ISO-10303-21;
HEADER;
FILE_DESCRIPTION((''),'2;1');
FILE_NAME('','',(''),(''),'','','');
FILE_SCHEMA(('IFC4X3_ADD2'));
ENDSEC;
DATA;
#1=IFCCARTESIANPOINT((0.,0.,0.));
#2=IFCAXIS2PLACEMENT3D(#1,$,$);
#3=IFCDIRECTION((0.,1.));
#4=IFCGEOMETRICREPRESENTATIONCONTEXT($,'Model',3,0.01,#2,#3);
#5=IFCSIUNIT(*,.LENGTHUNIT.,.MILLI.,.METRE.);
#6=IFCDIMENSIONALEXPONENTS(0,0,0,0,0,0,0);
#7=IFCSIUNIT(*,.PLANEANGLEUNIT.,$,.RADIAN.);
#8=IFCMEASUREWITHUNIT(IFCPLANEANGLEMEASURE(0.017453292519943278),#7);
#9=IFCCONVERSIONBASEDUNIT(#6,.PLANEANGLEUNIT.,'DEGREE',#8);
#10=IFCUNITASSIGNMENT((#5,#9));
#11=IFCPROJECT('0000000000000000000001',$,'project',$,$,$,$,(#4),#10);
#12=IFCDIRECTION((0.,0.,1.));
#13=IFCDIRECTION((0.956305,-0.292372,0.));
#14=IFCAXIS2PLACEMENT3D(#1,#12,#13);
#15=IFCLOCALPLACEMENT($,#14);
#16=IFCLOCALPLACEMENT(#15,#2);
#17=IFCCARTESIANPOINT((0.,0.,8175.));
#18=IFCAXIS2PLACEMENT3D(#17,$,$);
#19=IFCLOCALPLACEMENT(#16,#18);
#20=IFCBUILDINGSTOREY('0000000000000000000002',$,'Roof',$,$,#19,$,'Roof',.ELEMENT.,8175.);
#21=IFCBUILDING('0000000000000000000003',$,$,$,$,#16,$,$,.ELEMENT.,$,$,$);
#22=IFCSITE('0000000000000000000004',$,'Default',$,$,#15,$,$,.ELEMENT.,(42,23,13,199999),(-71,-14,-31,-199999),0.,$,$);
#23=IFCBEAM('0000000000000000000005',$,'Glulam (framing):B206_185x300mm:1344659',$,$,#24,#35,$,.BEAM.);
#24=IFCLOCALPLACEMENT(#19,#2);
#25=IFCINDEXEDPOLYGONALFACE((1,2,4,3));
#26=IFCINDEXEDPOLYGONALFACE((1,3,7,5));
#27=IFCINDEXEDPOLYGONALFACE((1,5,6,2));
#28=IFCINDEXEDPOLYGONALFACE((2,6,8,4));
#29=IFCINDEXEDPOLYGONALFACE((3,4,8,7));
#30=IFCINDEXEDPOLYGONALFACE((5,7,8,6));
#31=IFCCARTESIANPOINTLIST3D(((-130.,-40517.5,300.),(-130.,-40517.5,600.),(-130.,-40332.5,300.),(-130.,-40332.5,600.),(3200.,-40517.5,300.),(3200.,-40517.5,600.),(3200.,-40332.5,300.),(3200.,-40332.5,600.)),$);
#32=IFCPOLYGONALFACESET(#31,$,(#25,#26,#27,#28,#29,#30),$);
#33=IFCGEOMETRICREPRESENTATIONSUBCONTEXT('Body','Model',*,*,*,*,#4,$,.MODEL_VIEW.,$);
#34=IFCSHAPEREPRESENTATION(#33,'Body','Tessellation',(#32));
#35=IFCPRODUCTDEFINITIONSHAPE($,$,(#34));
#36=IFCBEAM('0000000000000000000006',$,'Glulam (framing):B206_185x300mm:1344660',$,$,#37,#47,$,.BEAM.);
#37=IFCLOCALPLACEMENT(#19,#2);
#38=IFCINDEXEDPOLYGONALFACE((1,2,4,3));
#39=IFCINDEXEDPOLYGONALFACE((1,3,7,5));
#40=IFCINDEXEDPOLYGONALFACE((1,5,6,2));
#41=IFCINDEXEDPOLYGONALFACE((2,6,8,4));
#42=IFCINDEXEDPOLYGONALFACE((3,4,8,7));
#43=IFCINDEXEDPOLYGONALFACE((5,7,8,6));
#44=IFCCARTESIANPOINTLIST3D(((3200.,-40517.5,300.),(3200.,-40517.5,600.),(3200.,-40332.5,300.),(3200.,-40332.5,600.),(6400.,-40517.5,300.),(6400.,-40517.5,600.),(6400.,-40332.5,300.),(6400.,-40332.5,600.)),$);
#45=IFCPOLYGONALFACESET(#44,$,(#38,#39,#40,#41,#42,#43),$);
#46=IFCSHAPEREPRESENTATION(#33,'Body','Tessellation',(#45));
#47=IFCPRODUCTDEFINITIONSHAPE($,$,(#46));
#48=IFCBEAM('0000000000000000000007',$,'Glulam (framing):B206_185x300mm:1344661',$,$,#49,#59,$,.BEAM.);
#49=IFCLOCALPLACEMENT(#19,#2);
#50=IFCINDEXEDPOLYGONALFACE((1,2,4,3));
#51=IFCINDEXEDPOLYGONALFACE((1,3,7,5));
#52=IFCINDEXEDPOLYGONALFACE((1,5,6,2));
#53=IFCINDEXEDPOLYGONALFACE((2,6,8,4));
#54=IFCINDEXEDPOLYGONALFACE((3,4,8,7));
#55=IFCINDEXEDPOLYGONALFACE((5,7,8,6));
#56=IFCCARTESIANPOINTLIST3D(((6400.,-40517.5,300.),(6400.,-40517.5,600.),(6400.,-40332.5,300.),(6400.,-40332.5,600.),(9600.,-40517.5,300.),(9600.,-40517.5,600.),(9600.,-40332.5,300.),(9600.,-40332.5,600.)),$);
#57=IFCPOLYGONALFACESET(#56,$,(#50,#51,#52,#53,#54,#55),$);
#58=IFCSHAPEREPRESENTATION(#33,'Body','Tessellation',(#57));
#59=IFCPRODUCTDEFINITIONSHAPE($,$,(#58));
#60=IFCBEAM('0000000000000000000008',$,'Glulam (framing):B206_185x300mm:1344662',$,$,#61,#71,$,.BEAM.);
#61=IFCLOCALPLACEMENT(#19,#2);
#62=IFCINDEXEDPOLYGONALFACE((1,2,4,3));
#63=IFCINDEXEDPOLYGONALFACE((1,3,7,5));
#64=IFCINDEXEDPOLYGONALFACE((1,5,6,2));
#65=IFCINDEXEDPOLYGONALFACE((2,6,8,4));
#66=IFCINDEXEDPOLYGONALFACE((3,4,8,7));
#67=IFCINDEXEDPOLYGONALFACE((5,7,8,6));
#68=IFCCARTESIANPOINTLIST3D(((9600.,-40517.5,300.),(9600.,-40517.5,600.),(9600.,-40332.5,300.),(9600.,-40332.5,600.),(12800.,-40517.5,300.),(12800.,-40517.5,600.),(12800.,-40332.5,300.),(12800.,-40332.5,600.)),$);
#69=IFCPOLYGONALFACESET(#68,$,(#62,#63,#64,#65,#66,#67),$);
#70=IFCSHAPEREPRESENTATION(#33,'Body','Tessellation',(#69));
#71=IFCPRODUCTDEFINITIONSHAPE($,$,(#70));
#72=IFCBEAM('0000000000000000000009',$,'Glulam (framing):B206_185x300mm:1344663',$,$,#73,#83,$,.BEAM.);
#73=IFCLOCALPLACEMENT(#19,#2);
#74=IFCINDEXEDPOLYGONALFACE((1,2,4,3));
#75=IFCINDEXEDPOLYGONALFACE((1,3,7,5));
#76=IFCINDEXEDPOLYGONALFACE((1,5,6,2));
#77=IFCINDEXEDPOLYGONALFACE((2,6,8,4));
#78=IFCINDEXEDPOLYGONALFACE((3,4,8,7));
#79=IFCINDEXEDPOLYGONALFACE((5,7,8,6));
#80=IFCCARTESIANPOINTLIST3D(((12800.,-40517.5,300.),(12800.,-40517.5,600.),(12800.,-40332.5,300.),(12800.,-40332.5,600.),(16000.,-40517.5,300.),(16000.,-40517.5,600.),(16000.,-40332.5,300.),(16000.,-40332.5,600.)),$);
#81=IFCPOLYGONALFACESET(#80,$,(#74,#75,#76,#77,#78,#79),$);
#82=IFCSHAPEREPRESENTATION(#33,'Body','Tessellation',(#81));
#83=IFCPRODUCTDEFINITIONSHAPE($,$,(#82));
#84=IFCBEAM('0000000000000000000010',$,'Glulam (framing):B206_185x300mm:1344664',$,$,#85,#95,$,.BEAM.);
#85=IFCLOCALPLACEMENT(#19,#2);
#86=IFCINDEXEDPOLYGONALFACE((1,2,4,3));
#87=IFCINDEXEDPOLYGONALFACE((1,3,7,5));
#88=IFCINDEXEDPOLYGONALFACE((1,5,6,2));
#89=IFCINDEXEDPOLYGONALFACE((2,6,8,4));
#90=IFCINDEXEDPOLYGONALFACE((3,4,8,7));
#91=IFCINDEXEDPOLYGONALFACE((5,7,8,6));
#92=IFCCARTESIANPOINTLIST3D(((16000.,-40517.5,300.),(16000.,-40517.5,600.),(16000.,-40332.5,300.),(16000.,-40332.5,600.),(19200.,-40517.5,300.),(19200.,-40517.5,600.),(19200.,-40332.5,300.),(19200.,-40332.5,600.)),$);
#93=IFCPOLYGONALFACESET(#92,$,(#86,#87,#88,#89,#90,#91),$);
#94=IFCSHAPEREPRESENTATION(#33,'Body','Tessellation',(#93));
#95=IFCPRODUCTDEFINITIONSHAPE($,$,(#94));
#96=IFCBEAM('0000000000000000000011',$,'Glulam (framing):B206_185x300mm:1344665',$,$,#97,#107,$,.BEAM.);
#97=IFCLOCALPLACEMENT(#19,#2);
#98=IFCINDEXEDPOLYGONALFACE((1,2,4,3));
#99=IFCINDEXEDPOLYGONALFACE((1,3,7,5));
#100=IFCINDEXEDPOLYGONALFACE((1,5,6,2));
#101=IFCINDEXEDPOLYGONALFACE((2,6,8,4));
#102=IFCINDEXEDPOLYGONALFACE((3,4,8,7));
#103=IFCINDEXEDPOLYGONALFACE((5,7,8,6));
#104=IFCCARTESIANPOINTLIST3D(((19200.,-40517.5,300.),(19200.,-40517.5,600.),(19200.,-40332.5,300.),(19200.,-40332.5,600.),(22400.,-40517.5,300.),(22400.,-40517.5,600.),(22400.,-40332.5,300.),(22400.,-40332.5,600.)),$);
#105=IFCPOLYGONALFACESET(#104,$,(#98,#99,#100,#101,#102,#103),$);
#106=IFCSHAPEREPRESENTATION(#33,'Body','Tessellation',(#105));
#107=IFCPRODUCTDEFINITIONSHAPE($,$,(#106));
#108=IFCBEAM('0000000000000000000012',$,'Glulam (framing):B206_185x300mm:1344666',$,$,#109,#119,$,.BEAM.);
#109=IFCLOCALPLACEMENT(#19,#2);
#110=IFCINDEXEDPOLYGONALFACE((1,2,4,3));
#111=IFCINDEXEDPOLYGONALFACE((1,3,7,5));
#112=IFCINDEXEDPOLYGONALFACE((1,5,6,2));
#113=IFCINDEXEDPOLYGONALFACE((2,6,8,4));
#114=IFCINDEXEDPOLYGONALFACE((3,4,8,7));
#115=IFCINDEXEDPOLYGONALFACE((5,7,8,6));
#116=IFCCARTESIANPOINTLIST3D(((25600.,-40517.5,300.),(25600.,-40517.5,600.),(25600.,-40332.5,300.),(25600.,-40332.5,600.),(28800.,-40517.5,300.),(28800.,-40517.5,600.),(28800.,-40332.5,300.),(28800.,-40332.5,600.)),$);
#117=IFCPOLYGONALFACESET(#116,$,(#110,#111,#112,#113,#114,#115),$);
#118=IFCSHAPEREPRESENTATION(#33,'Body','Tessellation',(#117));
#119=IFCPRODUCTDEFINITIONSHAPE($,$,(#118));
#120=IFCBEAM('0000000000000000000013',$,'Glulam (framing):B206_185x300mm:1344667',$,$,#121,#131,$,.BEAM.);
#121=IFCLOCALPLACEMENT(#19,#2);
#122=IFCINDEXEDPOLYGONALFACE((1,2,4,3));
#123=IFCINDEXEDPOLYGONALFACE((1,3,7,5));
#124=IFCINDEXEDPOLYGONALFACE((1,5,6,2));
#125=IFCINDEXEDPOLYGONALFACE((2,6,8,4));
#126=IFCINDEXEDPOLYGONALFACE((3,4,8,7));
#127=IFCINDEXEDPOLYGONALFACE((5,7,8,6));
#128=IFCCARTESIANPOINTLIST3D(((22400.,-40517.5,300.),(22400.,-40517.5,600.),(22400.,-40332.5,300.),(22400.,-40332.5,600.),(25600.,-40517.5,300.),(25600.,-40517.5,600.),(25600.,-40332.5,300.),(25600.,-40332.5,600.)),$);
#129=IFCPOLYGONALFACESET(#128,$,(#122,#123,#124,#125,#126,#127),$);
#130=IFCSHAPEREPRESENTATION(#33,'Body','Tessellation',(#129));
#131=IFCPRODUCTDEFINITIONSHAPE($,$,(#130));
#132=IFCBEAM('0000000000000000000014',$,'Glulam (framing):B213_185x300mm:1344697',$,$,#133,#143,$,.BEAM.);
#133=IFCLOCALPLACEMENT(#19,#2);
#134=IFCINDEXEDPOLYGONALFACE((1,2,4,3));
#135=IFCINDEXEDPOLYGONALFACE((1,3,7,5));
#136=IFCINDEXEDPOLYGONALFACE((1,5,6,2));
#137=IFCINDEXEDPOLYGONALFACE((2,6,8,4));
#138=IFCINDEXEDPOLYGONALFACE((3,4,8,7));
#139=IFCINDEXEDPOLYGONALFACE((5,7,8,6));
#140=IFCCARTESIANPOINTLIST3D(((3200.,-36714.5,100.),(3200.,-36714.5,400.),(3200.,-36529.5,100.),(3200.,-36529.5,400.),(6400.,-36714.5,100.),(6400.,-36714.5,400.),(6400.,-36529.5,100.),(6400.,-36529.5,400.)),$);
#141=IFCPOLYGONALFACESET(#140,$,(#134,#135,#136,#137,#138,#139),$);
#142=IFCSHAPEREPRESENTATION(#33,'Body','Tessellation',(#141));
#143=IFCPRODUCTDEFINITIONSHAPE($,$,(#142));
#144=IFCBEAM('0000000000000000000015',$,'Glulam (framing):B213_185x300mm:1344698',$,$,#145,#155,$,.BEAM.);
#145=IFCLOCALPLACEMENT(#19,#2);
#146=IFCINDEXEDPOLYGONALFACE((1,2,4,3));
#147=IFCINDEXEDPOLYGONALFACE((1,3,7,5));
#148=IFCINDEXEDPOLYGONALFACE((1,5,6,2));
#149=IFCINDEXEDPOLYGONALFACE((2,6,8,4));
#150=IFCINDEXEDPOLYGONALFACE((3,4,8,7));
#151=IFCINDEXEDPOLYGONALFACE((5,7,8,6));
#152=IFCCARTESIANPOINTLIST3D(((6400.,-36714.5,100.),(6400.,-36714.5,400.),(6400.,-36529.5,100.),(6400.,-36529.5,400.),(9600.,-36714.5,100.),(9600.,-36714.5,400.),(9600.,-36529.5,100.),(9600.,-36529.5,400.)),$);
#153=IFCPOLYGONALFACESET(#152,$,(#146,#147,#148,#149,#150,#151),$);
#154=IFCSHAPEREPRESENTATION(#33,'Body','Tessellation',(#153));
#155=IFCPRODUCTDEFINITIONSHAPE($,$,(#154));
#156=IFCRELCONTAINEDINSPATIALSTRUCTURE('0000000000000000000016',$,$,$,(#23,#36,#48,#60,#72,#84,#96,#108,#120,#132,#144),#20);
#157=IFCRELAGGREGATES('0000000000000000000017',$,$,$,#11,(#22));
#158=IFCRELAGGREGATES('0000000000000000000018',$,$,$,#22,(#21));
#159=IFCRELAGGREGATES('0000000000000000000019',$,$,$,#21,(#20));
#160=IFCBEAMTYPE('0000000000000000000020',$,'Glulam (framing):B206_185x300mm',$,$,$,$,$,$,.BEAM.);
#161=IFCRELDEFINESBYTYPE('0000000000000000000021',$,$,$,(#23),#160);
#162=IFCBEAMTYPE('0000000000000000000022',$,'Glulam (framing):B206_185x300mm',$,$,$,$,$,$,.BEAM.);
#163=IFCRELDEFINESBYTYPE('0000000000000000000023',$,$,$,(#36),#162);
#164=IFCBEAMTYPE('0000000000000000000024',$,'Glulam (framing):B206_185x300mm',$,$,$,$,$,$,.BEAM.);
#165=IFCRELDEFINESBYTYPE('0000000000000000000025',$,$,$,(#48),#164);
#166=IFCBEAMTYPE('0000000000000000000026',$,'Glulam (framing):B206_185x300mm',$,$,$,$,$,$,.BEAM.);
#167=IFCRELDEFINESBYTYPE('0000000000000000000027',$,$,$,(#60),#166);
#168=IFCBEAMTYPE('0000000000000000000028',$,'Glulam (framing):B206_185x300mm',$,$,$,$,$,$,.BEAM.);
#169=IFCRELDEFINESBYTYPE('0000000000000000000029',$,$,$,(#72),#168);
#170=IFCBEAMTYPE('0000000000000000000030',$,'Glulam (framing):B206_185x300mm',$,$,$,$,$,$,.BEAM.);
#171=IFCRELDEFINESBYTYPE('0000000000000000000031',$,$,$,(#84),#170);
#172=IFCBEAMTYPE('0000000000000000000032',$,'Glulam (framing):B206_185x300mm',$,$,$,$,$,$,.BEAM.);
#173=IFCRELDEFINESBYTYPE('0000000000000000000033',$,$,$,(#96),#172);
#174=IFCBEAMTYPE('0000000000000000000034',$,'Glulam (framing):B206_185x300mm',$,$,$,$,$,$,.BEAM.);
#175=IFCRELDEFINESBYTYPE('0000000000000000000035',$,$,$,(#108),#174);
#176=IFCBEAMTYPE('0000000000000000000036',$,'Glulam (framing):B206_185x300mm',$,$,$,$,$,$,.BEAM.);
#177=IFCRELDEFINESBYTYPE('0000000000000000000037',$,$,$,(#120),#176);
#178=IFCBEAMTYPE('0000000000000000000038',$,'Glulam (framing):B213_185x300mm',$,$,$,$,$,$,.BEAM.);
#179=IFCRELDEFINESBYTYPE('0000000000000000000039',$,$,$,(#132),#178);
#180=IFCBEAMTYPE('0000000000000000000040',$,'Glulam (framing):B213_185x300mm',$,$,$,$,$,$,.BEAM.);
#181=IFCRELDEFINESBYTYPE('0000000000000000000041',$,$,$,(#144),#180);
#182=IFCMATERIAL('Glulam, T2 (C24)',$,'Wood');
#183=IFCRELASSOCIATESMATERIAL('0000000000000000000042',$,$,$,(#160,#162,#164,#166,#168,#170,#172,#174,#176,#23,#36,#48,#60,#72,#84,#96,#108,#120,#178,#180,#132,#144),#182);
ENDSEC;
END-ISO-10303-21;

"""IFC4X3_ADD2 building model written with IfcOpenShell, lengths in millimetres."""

from ifc_helpers import new_model, entity, si_unit, converted_unit, direction, frame, origin, origin_2d_with_axis, place, context, subcontext, project, spatial, rectangle, extrude, source, transform, mapped, material, material_profile, profile_set, profile_usage, type_object, type_shapes, element, save


model = new_model("IFC4X3_ADD2")

# Units and contexts
model_context = context("Model", 3, precision=0.01, world=origin(), true_north=direction((0.0, 1.0)))
body_context = subcontext(model_context, "Body", "Model", "MODEL_VIEW")
ifc_project = project(units=[si_unit("LENGTHUNIT", "METRE", prefix="MILLI"), converted_unit("PLANEANGLEUNIT", "DEGREE", entity("IfcPlaneAngleMeasure", 0.017453292519943278), si_unit("PLANEANGLEUNIT", "RADIAN"), dimensions=[0, 0, 0, 0, 0, 0, 0])], contexts=[model_context])

# Site, building, storey
site_placement = place(None, frame((0.0, 0.0, 0.0), z_axis=(0.0, 0.0, 1.0), x_axis=(0.956305, -0.292372, 0.0)))
site = spatial("IfcSite", under=ifc_project, at=site_placement, Name="Default", CompositionType="ELEMENT", RefLatitude=(42, 23, 13, 199999), RefLongitude=(-71, -14, -31, -199999), RefElevation=0.0)
building_placement = place(site_placement, origin())
building = spatial("IfcBuilding", under=site, at=building_placement, CompositionType="ELEMENT")
storey_placement = place(building_placement, frame((0.0, 0.0, 8175.0)))
storey = spatial("IfcBuildingStorey", under=building, at=storey_placement, Name="Roof", LongName="Roof", CompositionType="ELEMENT", Elevation=8175.0)

# Beams
ifc_material = material(Name="Glulam, T2 (C24)", Category="Wood")
ifc_material_profile_1 = material_profile(ifc_material, rectangle(XDim=3330.0, YDim=185.0, at=origin_2d_with_axis()), Name="B206_185x300mm")
ifc_profile_set_1 = profile_set([ifc_material_profile_1], Name="B206_185x300mm")
ifc_profile_usage_1 = profile_usage(ifc_profile_set_1, cardinal=8)
beam_type_1 = type_object("IfcBeamType", Name="Glulam (framing):B206_185x300mm", PredefinedType="BEAM", material=ifc_profile_set_1)
shared_shape_1 = source(origin(), body_context, "Body", "SweptSolid", [
    extrude(rectangle(XDim=3330.0, YDim=185.0, at=origin_2d_with_axis()), frame((-65.0, 0.0, -150.0), z_axis=(0.0, 0.0, 1.0), x_axis=(-1.0, 0.0, 0.0)), (0.0, 0.0, 1.0), 300.0),
])
type_shapes(beam_type_1, [shared_shape_1])
beam_1_placement = place(storey_placement, frame((1600.0, -40425.0, 450.0)))
element("IfcBeam", 1, at=beam_1_placement, inside=storey, type_object=beam_type_1, material=ifc_profile_usage_1, Name="Glulam (framing):B206_185x300mm:1344659", PredefinedType="BEAM", context=body_context, shape_type="MappedRepresentation", body=[
    mapped(shared_shape_1, transform((0.0, 0.0, 0.0), scale=1.0)),
])
beam_type_2 = type_object("IfcBeamType", Name="Glulam (framing):B206_185x300mm", PredefinedType="BEAM", material=ifc_profile_set_1)
shared_shape_2 = source(origin(), body_context, "Body", "SweptSolid", [
    extrude(rectangle(XDim=3200.0, YDim=185.0, at=origin_2d_with_axis()), frame((0.0, 0.0, -150.0), z_axis=(0.0, 0.0, 1.0), x_axis=(-1.0, 0.0, 0.0)), (0.0, 0.0, 1.0), 300.0),
])
type_shapes(beam_type_2, [shared_shape_2])
beam_2_placement = place(storey_placement, frame((4800.0, -40425.0, 450.0)))
element("IfcBeam", 2, at=beam_2_placement, inside=storey, type_object=beam_type_2, material=ifc_profile_usage_1, Name="Glulam (framing):B206_185x300mm:1344660", PredefinedType="BEAM", context=body_context, shape_type="MappedRepresentation", body=[
    mapped(shared_shape_2, transform((0.0, 0.0, 0.0), scale=1.0)),
])
beam_type_3 = type_object("IfcBeamType", Name="Glulam (framing):B206_185x300mm", PredefinedType="BEAM", material=ifc_profile_set_1)
shared_shape_3 = source(origin(), body_context, "Body", "SweptSolid", [
    extrude(rectangle(XDim=3200.0, YDim=185.0, at=origin_2d_with_axis()), frame((0.0, 0.0, -150.0), z_axis=(0.0, 0.0, 1.0), x_axis=(-1.0, 0.0, 0.0)), (0.0, 0.0, 1.0), 300.0),
])
type_shapes(beam_type_3, [shared_shape_3])
beam_3_placement = place(storey_placement, frame((8000.0, -40425.0, 450.0)))
element("IfcBeam", 3, at=beam_3_placement, inside=storey, type_object=beam_type_3, material=ifc_profile_usage_1, Name="Glulam (framing):B206_185x300mm:1344661", PredefinedType="BEAM", context=body_context, shape_type="MappedRepresentation", body=[
    mapped(shared_shape_3, transform((0.0, 0.0, 0.0), scale=1.0)),
])
beam_type_4 = type_object("IfcBeamType", Name="Glulam (framing):B206_185x300mm", PredefinedType="BEAM", material=ifc_profile_set_1)
shared_shape_4 = source(origin(), body_context, "Body", "SweptSolid", [
    extrude(rectangle(XDim=3200.0, YDim=185.0, at=origin_2d_with_axis()), frame((0.0, 0.0, -150.0), z_axis=(0.0, 0.0, 1.0), x_axis=(-1.0, 0.0, 0.0)), (0.0, 0.0, 1.0), 300.0),
])
type_shapes(beam_type_4, [shared_shape_4])
beam_4_placement = place(storey_placement, frame((11200.0, -40425.0, 450.0)))
element("IfcBeam", 4, at=beam_4_placement, inside=storey, type_object=beam_type_4, material=ifc_profile_usage_1, Name="Glulam (framing):B206_185x300mm:1344662", PredefinedType="BEAM", context=body_context, shape_type="MappedRepresentation", body=[
    mapped(shared_shape_4, transform((0.0, 0.0, 0.0), scale=1.0)),
])
beam_type_5 = type_object("IfcBeamType", Name="Glulam (framing):B206_185x300mm", PredefinedType="BEAM", material=ifc_profile_set_1)
shared_shape_5 = source(origin(), body_context, "Body", "SweptSolid", [
    extrude(rectangle(XDim=3200.0, YDim=185.0, at=origin_2d_with_axis()), frame((0.0, 0.0, -150.0), z_axis=(0.0, 0.0, 1.0), x_axis=(-1.0, 0.0, 0.0)), (0.0, 0.0, 1.0), 300.0),
])
type_shapes(beam_type_5, [shared_shape_5])
beam_5_placement = place(storey_placement, frame((14400.0, -40425.0, 450.0)))
element("IfcBeam", 5, at=beam_5_placement, inside=storey, type_object=beam_type_5, material=ifc_profile_usage_1, Name="Glulam (framing):B206_185x300mm:1344663", PredefinedType="BEAM", context=body_context, shape_type="MappedRepresentation", body=[
    mapped(shared_shape_5, transform((0.0, 0.0, 0.0), scale=1.0)),
])
beam_type_6 = type_object("IfcBeamType", Name="Glulam (framing):B206_185x300mm", PredefinedType="BEAM", material=ifc_profile_set_1)
shared_shape_6 = source(origin(), body_context, "Body", "SweptSolid", [
    extrude(rectangle(XDim=3200.0, YDim=185.0, at=origin_2d_with_axis()), frame((0.0, 0.0, -150.0), z_axis=(0.0, 0.0, 1.0), x_axis=(-1.0, 0.0, 0.0)), (0.0, 0.0, 1.0), 300.0),
])
type_shapes(beam_type_6, [shared_shape_6])
beam_6_placement = place(storey_placement, frame((17600.0, -40425.0, 450.0)))
element("IfcBeam", 6, at=beam_6_placement, inside=storey, type_object=beam_type_6, material=ifc_profile_usage_1, Name="Glulam (framing):B206_185x300mm:1344664", PredefinedType="BEAM", context=body_context, shape_type="MappedRepresentation", body=[
    mapped(shared_shape_6, transform((0.0, 0.0, 0.0), scale=1.0)),
])
beam_type_7 = type_object("IfcBeamType", Name="Glulam (framing):B206_185x300mm", PredefinedType="BEAM", material=ifc_profile_set_1)
shared_shape_7 = source(origin(), body_context, "Body", "SweptSolid", [
    extrude(rectangle(XDim=3200.0, YDim=185.0, at=origin_2d_with_axis()), frame((0.0, 0.0, -150.0), z_axis=(0.0, 0.0, 1.0), x_axis=(-1.0, 0.0, 0.0)), (0.0, 0.0, 1.0), 300.0),
])
type_shapes(beam_type_7, [shared_shape_7])
beam_7_placement = place(storey_placement, frame((20800.0, -40425.0, 450.0)))
element("IfcBeam", 7, at=beam_7_placement, inside=storey, type_object=beam_type_7, material=ifc_profile_usage_1, Name="Glulam (framing):B206_185x300mm:1344665", PredefinedType="BEAM", context=body_context, shape_type="MappedRepresentation", body=[
    mapped(shared_shape_7, transform((0.0, 0.0, 0.0), scale=1.0)),
])
beam_type_8 = type_object("IfcBeamType", Name="Glulam (framing):B206_185x300mm", PredefinedType="BEAM", material=ifc_profile_set_1)
shared_shape_8 = source(origin(), body_context, "Body", "SweptSolid", [
    extrude(rectangle(XDim=3200.0, YDim=185.0, at=origin_2d_with_axis()), frame((0.0, 0.0, -150.0), z_axis=(0.0, 0.0, 1.0), x_axis=(-1.0, 0.0, 0.0)), (0.0, 0.0, 1.0), 300.0),
])
type_shapes(beam_type_8, [shared_shape_8])
beam_8_placement = place(storey_placement, frame((27200.0, -40425.0, 450.0)))
element("IfcBeam", 8, at=beam_8_placement, inside=storey, type_object=beam_type_8, material=ifc_profile_usage_1, Name="Glulam (framing):B206_185x300mm:1344666", PredefinedType="BEAM", context=body_context, shape_type="MappedRepresentation", body=[
    mapped(shared_shape_8, transform((0.0, 0.0, 0.0), scale=1.0)),
])
beam_type_9 = type_object("IfcBeamType", Name="Glulam (framing):B206_185x300mm", PredefinedType="BEAM", material=ifc_profile_set_1)
shared_shape_9 = source(origin(), body_context, "Body", "SweptSolid", [
    extrude(rectangle(XDim=3200.0, YDim=185.0, at=origin_2d_with_axis()), frame((0.0, 0.0, -150.0), z_axis=(0.0, 0.0, 1.0), x_axis=(-1.0, 0.0, 0.0)), (0.0, 0.0, 1.0), 300.0),
])
type_shapes(beam_type_9, [shared_shape_9])
beam_9_placement = place(storey_placement, frame((24000.0, -40425.0, 450.0)))
element("IfcBeam", 9, at=beam_9_placement, inside=storey, type_object=beam_type_9, material=ifc_profile_usage_1, Name="Glulam (framing):B206_185x300mm:1344667", PredefinedType="BEAM", context=body_context, shape_type="MappedRepresentation", body=[
    mapped(shared_shape_9, transform((0.0, 0.0, 0.0), scale=1.0)),
])
ifc_material_profile_2 = material_profile(ifc_material, rectangle(XDim=3200.0, YDim=185.0, at=origin_2d_with_axis()), Name="B213_185x300mm")
ifc_profile_set_2 = profile_set([ifc_material_profile_2], Name="B213_185x300mm")
ifc_profile_usage_2 = profile_usage(ifc_profile_set_2, cardinal=8)
beam_type_10 = type_object("IfcBeamType", Name="Glulam (framing):B213_185x300mm", PredefinedType="BEAM", material=ifc_profile_set_2)
shared_shape_10 = source(origin(), body_context, "Body", "SweptSolid", [
    extrude(rectangle(XDim=3200.0, YDim=185.0, at=origin_2d_with_axis()), frame((0.0, 0.0, -150.0), z_axis=(0.0, 0.0, 1.0), x_axis=(-1.0, 0.0, 0.0)), (0.0, 0.0, 1.0), 300.0),
])
type_shapes(beam_type_10, [shared_shape_10])
beam_10_placement = place(storey_placement, frame((4800.0, -36622.0, 250.0), z_axis=(0.0, 0.0, 1.0), x_axis=(-1.0, 0.0, 0.0)))
element("IfcBeam", 10, at=beam_10_placement, inside=storey, type_object=beam_type_10, material=ifc_profile_usage_2, Name="Glulam (framing):B213_185x300mm:1344697", PredefinedType="BEAM", context=body_context, shape_type="MappedRepresentation", body=[
    mapped(shared_shape_10, transform((0.0, 0.0, 0.0), scale=1.0)),
])
beam_type_11 = type_object("IfcBeamType", Name="Glulam (framing):B213_185x300mm", PredefinedType="BEAM", material=ifc_profile_set_2)
shared_shape_11 = source(origin(), body_context, "Body", "SweptSolid", [
    extrude(rectangle(XDim=3200.0, YDim=185.0, at=origin_2d_with_axis()), frame((0.0, 0.0, -150.0), z_axis=(0.0, 0.0, 1.0), x_axis=(-1.0, 0.0, 0.0)), (0.0, 0.0, 1.0), 300.0),
])
type_shapes(beam_type_11, [shared_shape_11])
beam_11_placement = place(storey_placement, frame((8000.0, -36622.0, 250.0), z_axis=(0.0, 0.0, 1.0), x_axis=(-1.0, 0.0, 0.0)))
element("IfcBeam", 11, at=beam_11_placement, inside=storey, type_object=beam_type_11, material=ifc_profile_usage_2, Name="Glulam (framing):B213_185x300mm:1344698", PredefinedType="BEAM", context=body_context, shape_type="MappedRepresentation", body=[
    mapped(shared_shape_11, transform((0.0, 0.0, 0.0), scale=1.0)),
])

save(model, "model.ifc")
